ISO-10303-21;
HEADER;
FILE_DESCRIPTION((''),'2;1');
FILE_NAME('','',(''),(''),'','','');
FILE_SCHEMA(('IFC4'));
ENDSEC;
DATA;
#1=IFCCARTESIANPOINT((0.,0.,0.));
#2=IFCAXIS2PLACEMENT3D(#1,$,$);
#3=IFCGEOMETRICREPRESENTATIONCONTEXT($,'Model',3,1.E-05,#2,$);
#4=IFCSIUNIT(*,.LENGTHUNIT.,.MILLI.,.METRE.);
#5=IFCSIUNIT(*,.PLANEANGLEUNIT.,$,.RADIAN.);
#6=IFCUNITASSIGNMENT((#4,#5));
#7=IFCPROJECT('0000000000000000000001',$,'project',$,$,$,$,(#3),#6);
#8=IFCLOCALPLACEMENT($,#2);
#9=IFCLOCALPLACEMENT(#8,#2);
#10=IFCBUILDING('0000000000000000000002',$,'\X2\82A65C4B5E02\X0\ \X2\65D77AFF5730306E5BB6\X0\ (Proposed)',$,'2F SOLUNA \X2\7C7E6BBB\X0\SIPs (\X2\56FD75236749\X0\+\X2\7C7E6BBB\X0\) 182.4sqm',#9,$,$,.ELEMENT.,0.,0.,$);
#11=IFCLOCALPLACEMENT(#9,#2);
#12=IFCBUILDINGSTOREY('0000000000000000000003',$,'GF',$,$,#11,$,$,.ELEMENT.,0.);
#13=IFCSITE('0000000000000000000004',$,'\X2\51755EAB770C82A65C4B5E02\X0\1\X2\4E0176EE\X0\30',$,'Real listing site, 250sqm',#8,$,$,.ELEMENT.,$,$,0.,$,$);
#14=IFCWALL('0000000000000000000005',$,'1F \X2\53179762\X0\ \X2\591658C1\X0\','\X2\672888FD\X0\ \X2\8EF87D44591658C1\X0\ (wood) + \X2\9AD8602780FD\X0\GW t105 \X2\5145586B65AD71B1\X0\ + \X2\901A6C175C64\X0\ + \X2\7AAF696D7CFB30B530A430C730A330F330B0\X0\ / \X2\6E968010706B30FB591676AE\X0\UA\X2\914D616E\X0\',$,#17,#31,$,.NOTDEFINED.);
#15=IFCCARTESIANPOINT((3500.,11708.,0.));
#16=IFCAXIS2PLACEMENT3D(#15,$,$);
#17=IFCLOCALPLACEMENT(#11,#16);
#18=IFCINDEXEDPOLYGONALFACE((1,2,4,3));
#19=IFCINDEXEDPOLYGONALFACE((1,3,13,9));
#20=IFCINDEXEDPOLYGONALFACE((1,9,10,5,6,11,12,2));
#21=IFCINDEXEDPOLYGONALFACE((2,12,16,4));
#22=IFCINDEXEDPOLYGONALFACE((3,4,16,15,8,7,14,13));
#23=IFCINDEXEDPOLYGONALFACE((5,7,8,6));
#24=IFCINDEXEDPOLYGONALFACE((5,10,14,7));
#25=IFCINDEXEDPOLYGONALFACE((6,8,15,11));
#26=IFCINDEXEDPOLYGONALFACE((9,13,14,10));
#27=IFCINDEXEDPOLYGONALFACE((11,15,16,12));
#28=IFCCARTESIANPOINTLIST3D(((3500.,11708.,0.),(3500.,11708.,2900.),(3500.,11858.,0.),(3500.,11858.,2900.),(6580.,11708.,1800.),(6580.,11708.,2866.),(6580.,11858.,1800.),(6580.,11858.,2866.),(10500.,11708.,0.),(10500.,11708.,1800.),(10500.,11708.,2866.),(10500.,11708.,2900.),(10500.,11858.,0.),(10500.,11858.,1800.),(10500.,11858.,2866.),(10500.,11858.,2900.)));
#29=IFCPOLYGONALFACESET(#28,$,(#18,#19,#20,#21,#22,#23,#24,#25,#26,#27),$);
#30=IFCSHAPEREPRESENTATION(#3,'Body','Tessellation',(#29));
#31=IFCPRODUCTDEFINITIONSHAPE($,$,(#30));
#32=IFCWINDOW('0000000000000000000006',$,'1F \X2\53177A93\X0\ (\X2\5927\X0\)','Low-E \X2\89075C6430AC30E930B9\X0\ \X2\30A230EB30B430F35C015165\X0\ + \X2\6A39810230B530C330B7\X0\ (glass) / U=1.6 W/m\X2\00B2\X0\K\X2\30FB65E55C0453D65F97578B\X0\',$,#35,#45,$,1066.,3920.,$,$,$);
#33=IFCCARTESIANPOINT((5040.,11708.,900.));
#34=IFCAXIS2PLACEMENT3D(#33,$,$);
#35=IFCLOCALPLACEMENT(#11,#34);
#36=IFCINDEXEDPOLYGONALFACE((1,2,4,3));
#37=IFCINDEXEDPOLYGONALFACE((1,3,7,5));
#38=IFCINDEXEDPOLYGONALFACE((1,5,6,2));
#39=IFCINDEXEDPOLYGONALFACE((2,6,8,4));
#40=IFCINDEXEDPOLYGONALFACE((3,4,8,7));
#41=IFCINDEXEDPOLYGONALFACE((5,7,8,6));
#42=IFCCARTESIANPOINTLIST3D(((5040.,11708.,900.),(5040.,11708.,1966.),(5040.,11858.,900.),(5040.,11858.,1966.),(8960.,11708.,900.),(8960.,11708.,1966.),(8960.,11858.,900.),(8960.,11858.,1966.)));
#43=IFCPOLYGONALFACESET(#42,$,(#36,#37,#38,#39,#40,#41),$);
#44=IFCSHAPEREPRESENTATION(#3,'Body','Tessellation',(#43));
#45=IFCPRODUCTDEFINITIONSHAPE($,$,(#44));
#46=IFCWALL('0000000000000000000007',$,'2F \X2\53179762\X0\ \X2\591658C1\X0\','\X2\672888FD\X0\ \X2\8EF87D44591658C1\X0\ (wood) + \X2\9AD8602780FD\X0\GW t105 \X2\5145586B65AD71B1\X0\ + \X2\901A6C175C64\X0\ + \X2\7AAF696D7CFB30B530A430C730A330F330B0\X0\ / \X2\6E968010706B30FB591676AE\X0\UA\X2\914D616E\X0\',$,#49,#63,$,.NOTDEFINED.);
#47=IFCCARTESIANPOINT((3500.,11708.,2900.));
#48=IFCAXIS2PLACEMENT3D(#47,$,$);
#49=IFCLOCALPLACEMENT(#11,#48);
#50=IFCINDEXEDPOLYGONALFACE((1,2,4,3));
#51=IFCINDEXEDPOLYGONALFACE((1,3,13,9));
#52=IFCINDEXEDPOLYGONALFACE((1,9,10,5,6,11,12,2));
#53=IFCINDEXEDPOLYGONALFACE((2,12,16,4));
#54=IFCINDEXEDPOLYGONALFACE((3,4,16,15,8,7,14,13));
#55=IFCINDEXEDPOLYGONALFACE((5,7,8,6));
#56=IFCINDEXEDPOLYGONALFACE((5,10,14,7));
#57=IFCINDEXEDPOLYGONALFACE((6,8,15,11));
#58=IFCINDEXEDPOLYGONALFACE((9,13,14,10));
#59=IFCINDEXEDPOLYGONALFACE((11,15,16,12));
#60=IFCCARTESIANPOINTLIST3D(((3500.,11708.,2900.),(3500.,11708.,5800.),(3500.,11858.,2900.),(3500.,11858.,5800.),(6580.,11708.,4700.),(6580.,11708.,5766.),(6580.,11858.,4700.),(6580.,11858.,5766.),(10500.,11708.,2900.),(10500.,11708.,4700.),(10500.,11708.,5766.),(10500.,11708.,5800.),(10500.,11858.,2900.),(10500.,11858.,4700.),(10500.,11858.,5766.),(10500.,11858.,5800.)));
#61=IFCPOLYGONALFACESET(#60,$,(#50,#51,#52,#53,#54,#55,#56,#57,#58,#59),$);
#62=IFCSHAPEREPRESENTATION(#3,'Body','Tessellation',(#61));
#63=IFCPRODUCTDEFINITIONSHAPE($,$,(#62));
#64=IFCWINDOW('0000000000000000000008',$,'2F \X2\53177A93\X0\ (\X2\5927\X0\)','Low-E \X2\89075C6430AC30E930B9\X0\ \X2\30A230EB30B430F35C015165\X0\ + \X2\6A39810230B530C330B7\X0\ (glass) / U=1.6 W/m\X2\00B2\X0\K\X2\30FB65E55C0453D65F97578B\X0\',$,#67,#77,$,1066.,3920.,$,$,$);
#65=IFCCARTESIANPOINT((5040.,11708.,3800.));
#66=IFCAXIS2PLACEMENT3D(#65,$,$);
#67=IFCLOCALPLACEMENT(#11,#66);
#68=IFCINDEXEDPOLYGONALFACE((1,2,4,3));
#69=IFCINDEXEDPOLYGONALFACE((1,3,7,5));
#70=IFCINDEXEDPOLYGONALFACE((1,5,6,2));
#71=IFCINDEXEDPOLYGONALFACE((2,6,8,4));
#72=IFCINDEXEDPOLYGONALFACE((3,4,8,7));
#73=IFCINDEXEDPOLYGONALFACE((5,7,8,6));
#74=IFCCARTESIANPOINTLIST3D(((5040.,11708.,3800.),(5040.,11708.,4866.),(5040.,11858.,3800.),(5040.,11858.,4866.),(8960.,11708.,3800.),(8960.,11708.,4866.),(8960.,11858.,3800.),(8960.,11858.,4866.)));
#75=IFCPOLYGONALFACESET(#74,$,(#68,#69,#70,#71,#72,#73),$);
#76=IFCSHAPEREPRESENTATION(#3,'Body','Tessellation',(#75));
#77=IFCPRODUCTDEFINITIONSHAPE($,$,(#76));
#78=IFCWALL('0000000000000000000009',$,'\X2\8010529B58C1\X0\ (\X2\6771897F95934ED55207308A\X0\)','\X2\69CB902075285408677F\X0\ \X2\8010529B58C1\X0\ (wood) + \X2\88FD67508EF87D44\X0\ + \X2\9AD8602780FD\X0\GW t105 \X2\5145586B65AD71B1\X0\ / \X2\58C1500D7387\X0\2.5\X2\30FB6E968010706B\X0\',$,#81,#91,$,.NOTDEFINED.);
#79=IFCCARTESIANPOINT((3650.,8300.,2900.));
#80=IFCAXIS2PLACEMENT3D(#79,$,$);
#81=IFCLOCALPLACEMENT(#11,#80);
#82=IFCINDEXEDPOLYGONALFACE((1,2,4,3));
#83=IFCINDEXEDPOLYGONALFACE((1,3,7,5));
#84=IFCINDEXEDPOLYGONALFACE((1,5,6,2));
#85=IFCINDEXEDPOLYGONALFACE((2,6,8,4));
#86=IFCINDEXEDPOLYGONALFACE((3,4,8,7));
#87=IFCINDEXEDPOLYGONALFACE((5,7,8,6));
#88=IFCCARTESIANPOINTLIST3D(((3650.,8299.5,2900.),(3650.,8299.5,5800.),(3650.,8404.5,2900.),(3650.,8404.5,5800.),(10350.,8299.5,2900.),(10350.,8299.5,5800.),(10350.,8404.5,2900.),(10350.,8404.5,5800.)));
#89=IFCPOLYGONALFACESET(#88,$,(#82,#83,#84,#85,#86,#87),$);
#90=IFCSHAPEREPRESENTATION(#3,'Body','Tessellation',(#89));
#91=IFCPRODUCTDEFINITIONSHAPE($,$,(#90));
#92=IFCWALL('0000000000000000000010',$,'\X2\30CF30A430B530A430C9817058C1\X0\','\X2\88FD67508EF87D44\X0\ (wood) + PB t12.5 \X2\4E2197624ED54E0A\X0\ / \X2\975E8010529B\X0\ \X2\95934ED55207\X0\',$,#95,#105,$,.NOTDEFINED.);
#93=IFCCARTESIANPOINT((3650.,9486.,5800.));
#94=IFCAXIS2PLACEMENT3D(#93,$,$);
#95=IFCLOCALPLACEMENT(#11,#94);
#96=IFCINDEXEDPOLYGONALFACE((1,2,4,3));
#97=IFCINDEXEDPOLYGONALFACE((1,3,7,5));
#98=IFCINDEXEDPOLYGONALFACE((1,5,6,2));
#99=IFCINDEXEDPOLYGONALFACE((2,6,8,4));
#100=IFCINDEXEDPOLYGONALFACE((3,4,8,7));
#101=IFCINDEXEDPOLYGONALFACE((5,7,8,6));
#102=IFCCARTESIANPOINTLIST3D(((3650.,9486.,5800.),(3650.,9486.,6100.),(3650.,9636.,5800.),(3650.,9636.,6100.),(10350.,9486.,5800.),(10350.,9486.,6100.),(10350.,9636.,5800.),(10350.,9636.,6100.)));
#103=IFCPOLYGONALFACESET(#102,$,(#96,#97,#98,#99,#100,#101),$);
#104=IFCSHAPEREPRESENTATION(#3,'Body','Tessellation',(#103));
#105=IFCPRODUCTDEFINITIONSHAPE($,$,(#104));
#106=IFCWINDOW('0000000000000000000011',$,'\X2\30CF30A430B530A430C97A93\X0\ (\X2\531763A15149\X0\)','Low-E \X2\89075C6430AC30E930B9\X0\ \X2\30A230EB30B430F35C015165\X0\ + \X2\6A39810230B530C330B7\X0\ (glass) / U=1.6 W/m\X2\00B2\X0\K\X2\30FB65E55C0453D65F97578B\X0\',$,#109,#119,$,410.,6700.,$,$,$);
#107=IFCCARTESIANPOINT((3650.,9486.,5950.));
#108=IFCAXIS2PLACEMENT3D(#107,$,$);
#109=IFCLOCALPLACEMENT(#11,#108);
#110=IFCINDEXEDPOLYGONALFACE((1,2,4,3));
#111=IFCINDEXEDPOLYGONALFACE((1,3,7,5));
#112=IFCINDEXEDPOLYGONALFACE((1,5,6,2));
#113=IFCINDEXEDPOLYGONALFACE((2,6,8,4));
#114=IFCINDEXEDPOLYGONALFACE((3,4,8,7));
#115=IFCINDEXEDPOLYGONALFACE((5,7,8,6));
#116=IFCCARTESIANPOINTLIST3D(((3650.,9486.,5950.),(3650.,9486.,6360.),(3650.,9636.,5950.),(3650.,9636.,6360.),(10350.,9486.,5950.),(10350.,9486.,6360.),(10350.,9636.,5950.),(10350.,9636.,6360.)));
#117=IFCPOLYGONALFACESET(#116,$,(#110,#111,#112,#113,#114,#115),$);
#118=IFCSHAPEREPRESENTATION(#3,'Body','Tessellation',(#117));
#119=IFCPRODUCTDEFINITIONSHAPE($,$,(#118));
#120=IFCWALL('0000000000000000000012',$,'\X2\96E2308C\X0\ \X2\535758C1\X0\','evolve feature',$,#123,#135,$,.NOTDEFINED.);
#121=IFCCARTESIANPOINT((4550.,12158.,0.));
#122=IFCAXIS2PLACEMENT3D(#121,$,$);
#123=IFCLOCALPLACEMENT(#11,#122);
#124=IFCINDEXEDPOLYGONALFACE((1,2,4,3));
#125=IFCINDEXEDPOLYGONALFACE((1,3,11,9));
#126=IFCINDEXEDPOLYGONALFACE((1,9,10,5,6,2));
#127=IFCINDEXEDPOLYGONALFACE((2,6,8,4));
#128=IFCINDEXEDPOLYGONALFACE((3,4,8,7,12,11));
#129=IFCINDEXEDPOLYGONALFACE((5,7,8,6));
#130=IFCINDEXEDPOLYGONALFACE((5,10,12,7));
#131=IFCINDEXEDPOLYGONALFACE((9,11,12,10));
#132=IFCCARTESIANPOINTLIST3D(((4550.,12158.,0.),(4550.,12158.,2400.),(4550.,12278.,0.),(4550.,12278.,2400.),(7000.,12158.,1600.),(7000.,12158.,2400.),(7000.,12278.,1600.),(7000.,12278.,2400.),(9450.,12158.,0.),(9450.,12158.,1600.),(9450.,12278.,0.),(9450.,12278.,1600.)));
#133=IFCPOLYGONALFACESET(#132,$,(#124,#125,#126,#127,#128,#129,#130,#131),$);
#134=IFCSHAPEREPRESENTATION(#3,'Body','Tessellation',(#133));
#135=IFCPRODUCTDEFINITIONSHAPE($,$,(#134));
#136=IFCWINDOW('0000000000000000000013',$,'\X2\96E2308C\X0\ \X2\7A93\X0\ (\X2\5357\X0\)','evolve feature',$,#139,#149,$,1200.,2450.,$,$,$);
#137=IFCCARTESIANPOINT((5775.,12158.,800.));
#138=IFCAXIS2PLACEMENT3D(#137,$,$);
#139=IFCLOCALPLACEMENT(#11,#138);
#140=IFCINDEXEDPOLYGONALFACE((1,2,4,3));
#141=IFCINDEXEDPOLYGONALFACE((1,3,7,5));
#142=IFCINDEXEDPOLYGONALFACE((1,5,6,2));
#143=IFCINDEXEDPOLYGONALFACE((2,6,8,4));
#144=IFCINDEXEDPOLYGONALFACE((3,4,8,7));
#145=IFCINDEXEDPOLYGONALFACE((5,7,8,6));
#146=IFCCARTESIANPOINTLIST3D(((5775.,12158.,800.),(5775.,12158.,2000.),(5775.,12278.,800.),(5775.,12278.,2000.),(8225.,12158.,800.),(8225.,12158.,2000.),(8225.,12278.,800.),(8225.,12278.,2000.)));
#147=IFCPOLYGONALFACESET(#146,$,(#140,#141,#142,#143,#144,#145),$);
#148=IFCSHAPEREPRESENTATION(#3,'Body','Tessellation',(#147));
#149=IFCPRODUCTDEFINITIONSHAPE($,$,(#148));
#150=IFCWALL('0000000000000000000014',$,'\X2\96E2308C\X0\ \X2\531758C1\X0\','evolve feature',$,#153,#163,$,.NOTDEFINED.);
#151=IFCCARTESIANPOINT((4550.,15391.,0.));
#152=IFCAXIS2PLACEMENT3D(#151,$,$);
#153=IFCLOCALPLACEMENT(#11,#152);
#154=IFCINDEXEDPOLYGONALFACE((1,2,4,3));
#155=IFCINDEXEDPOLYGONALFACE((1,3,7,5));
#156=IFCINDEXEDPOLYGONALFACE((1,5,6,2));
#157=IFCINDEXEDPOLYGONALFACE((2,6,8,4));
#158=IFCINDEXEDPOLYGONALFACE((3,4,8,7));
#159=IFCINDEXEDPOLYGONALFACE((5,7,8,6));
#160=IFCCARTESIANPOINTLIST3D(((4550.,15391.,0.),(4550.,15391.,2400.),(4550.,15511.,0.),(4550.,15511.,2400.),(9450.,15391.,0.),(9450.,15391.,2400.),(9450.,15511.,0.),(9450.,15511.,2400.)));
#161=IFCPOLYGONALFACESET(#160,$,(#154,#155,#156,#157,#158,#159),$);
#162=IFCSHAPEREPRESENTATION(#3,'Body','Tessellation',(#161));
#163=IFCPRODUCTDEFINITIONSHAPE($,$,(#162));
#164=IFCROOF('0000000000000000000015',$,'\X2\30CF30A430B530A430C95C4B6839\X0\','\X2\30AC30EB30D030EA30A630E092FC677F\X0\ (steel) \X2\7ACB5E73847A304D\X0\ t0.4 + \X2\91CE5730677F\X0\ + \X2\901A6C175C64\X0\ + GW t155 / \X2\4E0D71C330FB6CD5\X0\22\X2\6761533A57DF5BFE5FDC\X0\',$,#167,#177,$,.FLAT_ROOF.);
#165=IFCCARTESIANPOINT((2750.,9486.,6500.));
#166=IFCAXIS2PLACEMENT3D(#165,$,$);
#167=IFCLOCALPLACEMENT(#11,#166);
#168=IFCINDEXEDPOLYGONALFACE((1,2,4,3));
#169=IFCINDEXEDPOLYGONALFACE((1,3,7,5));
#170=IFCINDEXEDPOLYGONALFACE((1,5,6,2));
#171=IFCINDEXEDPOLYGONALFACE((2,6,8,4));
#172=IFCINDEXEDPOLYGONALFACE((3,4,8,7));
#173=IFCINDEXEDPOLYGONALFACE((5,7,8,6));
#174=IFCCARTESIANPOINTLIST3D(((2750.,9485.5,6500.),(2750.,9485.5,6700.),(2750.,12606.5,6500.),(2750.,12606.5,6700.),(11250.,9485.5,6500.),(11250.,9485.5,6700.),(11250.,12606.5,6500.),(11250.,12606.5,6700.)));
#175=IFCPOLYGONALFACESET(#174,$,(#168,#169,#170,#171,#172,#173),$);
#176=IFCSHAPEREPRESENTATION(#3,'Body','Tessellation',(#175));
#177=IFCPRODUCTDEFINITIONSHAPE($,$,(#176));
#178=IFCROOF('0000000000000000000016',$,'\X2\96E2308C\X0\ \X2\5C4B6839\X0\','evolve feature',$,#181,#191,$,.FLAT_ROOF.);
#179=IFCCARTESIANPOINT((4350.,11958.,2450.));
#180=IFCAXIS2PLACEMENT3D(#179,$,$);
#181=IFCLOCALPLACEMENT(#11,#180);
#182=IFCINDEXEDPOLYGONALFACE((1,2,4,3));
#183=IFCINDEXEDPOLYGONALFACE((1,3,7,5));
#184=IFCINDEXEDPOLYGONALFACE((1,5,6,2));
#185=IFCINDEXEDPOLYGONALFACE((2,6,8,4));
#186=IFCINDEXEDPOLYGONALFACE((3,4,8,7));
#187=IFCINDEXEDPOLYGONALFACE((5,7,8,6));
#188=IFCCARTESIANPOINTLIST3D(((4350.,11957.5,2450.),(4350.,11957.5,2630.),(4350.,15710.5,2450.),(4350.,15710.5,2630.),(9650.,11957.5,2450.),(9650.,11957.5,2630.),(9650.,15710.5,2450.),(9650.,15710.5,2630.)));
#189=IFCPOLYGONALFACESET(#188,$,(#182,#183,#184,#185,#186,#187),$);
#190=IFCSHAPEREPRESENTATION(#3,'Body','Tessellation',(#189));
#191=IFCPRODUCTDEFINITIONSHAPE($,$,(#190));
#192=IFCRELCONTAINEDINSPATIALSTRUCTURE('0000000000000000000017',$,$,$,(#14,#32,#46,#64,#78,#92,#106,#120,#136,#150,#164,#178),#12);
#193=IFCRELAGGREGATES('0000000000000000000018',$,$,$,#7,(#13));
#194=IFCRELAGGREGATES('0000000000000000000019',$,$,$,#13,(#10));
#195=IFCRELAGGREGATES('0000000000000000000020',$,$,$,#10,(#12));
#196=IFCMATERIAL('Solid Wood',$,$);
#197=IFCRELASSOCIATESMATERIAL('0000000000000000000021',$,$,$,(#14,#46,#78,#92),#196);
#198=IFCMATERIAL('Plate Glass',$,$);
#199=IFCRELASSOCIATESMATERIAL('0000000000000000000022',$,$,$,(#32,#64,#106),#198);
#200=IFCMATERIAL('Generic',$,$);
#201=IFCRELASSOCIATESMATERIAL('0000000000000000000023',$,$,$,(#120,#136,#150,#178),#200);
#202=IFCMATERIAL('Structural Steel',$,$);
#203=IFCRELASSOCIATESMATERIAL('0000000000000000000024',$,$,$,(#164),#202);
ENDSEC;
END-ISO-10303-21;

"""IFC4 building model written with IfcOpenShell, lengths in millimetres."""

from ifc_helpers import new_model, si_unit, frame, frame_2d, origin, place, context, project, spatial, rectangle, extrude, material, element, fill, save


model = new_model("IFC4")

# Units and contexts
model_context = context("Model", 3, precision=1e-05, world=origin())
ifc_project = project(units=[si_unit("LENGTHUNIT", "METRE", prefix="MILLI"), si_unit("PLANEANGLEUNIT", "RADIAN")], contexts=[model_context])

# Site, building, storey
site_placement = place(None, origin())
site = spatial("IfcSite", under=ifc_project, at=site_placement, Name="兵庫県芦屋市1丁目30", ObjectType="Real listing site, 250sqm", CompositionType="ELEMENT", RefElevation=0.0)
building_placement = place(site_placement, origin())
building = spatial("IfcBuilding", under=site, at=building_placement, Name="芦屋市 旗竿地の家 (Proposed)", ObjectType="2F SOLUNA 籾殻SIPs (国産杉+籾殻) 182.4sqm", CompositionType="ELEMENT", ElevationOfRefHeight=0.0, ElevationOfTerrain=0.0)
storey_placement = place(building_placement, origin())
storey = spatial("IfcBuildingStorey", under=building, at=storey_placement, Name="GF", CompositionType="ELEMENT", Elevation=0.0)

# Shared definitions
ifc_material_1 = material(Name="Generic")

# Wall, opening, window
ifc_material_2 = material(Name="Solid Wood")
wall_1_placement = place(storey_placement, frame((3500.0, 11708.0, 0.0)))
wall_1 = element("IfcWall", 1, at=wall_1_placement, inside=storey, material=ifc_material_2, Name="1F 北面 外壁", Description="木製 軸組外壁 (wood) + 高性能GW t105 充填断熱 + 通気層 + 窯業系サイディング / 準耐火・外皮UA配慮", PredefinedType="NOTDEFINED", context=model_context, shape_type="SweptSolid", body=[
    extrude(rectangle(XDim=7000.0, YDim=150.0, at=frame_2d((3500.0, 75.0))), frame((3500.0, 11708.0, 0.0)), (0.0, 0.0, 1.0), 2900.0),
])
opening_1_placement = place(storey_placement, frame((5040.0, 11708.0, 900.0)))
opening_1 = element("IfcOpeningElement", 2, at=opening_1_placement, cuts=wall_1, PredefinedType="NOTDEFINED", context=model_context, shape_type="SweptSolid", body=[
    extrude(rectangle(XDim=3920.0, YDim=150.0, at=frame_2d((1960.0, 75.0))), frame((5040.0, 11708.0, 900.0)), (0.0, 0.0, 1.0), 1066.0),
])
ifc_material_3 = material(Name="Plate Glass")
window_1_placement = place(storey_placement, frame((5040.0, 11708.0, 900.0)))
window_1 = element("IfcWindow", 3, at=window_1_placement, inside=storey, material=ifc_material_3, Name="1F 北窓 (大)", Description="Low-E 複層ガラス アルゴン封入 + 樹脂サッシ (glass) / U=1.6 W/m²K・日射取得型", OverallHeight=1066.0, OverallWidth=3920.0, context=model_context, shape_type="SweptSolid", body=[
    extrude(rectangle(XDim=3920.0, YDim=150.0, at=frame_2d((1960.0, 75.0))), frame((5040.0, 11708.0, 900.0)), (0.0, 0.0, 1.0), 1066.0),
])
fill(opening_1, window_1)

# Wall, opening, window
wall_2_placement = place(storey_placement, frame((3500.0, 11708.0, 2900.0)))
wall_2 = element("IfcWall", 4, at=wall_2_placement, inside=storey, material=ifc_material_2, Name="2F 北面 外壁", Description="木製 軸組外壁 (wood) + 高性能GW t105 充填断熱 + 通気層 + 窯業系サイディング / 準耐火・外皮UA配慮", PredefinedType="NOTDEFINED", context=model_context, shape_type="SweptSolid", body=[
    extrude(rectangle(XDim=7000.0, YDim=150.0, at=frame_2d((3500.0, 75.0))), frame((3500.0, 11708.0, 2900.0)), (0.0, 0.0, 1.0), 2900.0),
])
opening_2_placement = place(storey_placement, frame((5040.0, 11708.0, 3800.0)))
opening_2 = element("IfcOpeningElement", 5, at=opening_2_placement, cuts=wall_2, PredefinedType="NOTDEFINED", context=model_context, shape_type="SweptSolid", body=[
    extrude(rectangle(XDim=3920.0, YDim=150.0, at=frame_2d((1960.0, 75.0))), frame((5040.0, 11708.0, 3800.0)), (0.0, 0.0, 1.0), 1066.0),
])
window_2_placement = place(storey_placement, frame((5040.0, 11708.0, 3800.0)))
window_2 = element("IfcWindow", 6, at=window_2_placement, inside=storey, material=ifc_material_3, Name="2F 北窓 (大)", Description="Low-E 複層ガラス アルゴン封入 + 樹脂サッシ (glass) / U=1.6 W/m²K・日射取得型", OverallHeight=1066.0, OverallWidth=3920.0, context=model_context, shape_type="SweptSolid", body=[
    extrude(rectangle(XDim=3920.0, YDim=150.0, at=frame_2d((1960.0, 75.0))), frame((5040.0, 11708.0, 3800.0)), (0.0, 0.0, 1.0), 1066.0),
])
fill(opening_2, window_2)

# Wall
wall_3_placement = place(storey_placement, frame((3650.0, 8300.0, 2900.0)))
element("IfcWall", 7, at=wall_3_placement, inside=storey, material=ifc_material_2, Name="耐力壁 (東西間仕切り)", Description="構造用合板 耐力壁 (wood) + 製材軸組 + 高性能GW t105 充填断熱 / 壁倍率2.5・準耐火", PredefinedType="NOTDEFINED", context=model_context, shape_type="SweptSolid", body=[
    extrude(rectangle(XDim=6700.0, YDim=105.0, at=frame_2d((3350.0, 52.0))), frame((3650.0, 8300.0, 2900.0)), (0.0, 0.0, 1.0), 2900.0),
])

# Walls, openings, windows
wall_4_placement = place(storey_placement, frame((3650.0, 9486.0, 5800.0)))
wall_4 = element("IfcWall", 8, at=wall_4_placement, inside=storey, material=ifc_material_2, Name="ハイサイド腰壁", Description="製材軸組 (wood) + PB t12.5 両面仕上 / 非耐力 間仕切", PredefinedType="NOTDEFINED", context=model_context, shape_type="SweptSolid", body=[
    extrude(rectangle(XDim=6700.0, YDim=150.0, at=frame_2d((3350.0, 75.0))), frame((3650.0, 9486.0, 5800.0)), (0.0, 0.0, 1.0), 700.0),
])
opening_3_placement = place(storey_placement, frame((3650.0, 9486.0, 5950.0)))
opening_3 = element("IfcOpeningElement", 9, at=opening_3_placement, cuts=wall_4, PredefinedType="NOTDEFINED", context=model_context, shape_type="SweptSolid", body=[
    extrude(rectangle(XDim=6700.0, YDim=150.0, at=frame_2d((3350.0, 75.0))), frame((3650.0, 9486.0, 5950.0)), (0.0, 0.0, 1.0), 410.0),
])
window_3_placement = place(storey_placement, frame((3650.0, 9486.0, 5950.0)))
window_3 = element("IfcWindow", 10, at=window_3_placement, inside=storey, material=ifc_material_3, Name="ハイサイド窓 (北採光)", Description="Low-E 複層ガラス アルゴン封入 + 樹脂サッシ (glass) / U=1.6 W/m²K・日射取得型", OverallHeight=410.0, OverallWidth=6700.0, context=model_context, shape_type="SweptSolid", body=[
    extrude(rectangle(XDim=6700.0, YDim=150.0, at=frame_2d((3350.0, 75.0))), frame((3650.0, 9486.0, 5950.0)), (0.0, 0.0, 1.0), 410.0),
])
fill(opening_3, window_3)
wall_5_placement = place(storey_placement, frame((4550.0, 12158.0, 0.0)))
wall_5 = element("IfcWall", 11, at=wall_5_placement, inside=storey, material=ifc_material_1, Name="離れ 南壁", Description="evolve feature", PredefinedType="NOTDEFINED", context=model_context, shape_type="SweptSolid", body=[
    extrude(rectangle(XDim=4900.0, YDim=120.0, at=frame_2d((2450.0, 60.0))), frame((4550.0, 12158.0, 0.0)), (0.0, 0.0, 1.0), 2400.0),
])
opening_4_placement = place(storey_placement, frame((5775.0, 12158.0, 800.0)))
opening_4 = element("IfcOpeningElement", 12, at=opening_4_placement, cuts=wall_5, PredefinedType="NOTDEFINED", context=model_context, shape_type="SweptSolid", body=[
    extrude(rectangle(XDim=2450.0, YDim=120.0, at=frame_2d((1225.0, 60.0))), frame((5775.0, 12158.0, 800.0)), (0.0, 0.0, 1.0), 1200.0),
])
window_4_placement = place(storey_placement, frame((5775.0, 12158.0, 800.0)))
window_4 = element("IfcWindow", 13, at=window_4_placement, inside=storey, material=ifc_material_1, Name="離れ 窓 (南)", Description="evolve feature", OverallHeight=1200.0, OverallWidth=2450.0, context=model_context, shape_type="SweptSolid", body=[
    extrude(rectangle(XDim=2450.0, YDim=120.0, at=frame_2d((1225.0, 60.0))), frame((5775.0, 12158.0, 800.0)), (0.0, 0.0, 1.0), 1200.0),
])
fill(opening_4, window_4)

# Wall
wall_6_placement = place(storey_placement, frame((4550.0, 15391.0, 0.0)))
element("IfcWall", 14, at=wall_6_placement, inside=storey, material=ifc_material_1, Name="離れ 北壁", Description="evolve feature", PredefinedType="NOTDEFINED", context=model_context, shape_type="SweptSolid", body=[
    extrude(rectangle(XDim=4900.0, YDim=120.0, at=frame_2d((2450.0, 60.0))), frame((4550.0, 15391.0, 0.0)), (0.0, 0.0, 1.0), 2400.0),
])

# Roofs
ifc_material_4 = material(Name="Structural Steel")
roof_1_placement = place(storey_placement, frame((2750.0, 9486.0, 6500.0)))
element("IfcRoof", 15, at=roof_1_placement, inside=storey, material=ifc_material_4, Name="ハイサイド屋根", Description="ガルバリウム鋼板 (steel) 立平葺き t0.4 + 野地板 + 通気層 + GW t155 / 不燃・法22条区域対応", PredefinedType="FLAT_ROOF", context=model_context, shape_type="SweptSolid", body=[
    extrude(rectangle(XDim=8500.0, YDim=3121.0, at=frame_2d((4250.0, 1560.0))), frame((2750.0, 9486.0, 6500.0)), (0.0, 0.0, 1.0), 200.0),
])
roof_2_placement = place(storey_placement, frame((4350.0, 11958.0, 2450.0)))
element("IfcRoof", 16, at=roof_2_placement, inside=storey, material=ifc_material_1, Name="離れ 屋根", Description="evolve feature", PredefinedType="FLAT_ROOF", context=model_context, shape_type="SweptSolid", body=[
    extrude(rectangle(XDim=5300.0, YDim=3753.0, at=frame_2d((2650.0, 1876.0))), frame((4350.0, 11958.0, 2450.0)), (0.0, 0.0, 1.0), 180.0),
])

save(model, "model.ifc")
